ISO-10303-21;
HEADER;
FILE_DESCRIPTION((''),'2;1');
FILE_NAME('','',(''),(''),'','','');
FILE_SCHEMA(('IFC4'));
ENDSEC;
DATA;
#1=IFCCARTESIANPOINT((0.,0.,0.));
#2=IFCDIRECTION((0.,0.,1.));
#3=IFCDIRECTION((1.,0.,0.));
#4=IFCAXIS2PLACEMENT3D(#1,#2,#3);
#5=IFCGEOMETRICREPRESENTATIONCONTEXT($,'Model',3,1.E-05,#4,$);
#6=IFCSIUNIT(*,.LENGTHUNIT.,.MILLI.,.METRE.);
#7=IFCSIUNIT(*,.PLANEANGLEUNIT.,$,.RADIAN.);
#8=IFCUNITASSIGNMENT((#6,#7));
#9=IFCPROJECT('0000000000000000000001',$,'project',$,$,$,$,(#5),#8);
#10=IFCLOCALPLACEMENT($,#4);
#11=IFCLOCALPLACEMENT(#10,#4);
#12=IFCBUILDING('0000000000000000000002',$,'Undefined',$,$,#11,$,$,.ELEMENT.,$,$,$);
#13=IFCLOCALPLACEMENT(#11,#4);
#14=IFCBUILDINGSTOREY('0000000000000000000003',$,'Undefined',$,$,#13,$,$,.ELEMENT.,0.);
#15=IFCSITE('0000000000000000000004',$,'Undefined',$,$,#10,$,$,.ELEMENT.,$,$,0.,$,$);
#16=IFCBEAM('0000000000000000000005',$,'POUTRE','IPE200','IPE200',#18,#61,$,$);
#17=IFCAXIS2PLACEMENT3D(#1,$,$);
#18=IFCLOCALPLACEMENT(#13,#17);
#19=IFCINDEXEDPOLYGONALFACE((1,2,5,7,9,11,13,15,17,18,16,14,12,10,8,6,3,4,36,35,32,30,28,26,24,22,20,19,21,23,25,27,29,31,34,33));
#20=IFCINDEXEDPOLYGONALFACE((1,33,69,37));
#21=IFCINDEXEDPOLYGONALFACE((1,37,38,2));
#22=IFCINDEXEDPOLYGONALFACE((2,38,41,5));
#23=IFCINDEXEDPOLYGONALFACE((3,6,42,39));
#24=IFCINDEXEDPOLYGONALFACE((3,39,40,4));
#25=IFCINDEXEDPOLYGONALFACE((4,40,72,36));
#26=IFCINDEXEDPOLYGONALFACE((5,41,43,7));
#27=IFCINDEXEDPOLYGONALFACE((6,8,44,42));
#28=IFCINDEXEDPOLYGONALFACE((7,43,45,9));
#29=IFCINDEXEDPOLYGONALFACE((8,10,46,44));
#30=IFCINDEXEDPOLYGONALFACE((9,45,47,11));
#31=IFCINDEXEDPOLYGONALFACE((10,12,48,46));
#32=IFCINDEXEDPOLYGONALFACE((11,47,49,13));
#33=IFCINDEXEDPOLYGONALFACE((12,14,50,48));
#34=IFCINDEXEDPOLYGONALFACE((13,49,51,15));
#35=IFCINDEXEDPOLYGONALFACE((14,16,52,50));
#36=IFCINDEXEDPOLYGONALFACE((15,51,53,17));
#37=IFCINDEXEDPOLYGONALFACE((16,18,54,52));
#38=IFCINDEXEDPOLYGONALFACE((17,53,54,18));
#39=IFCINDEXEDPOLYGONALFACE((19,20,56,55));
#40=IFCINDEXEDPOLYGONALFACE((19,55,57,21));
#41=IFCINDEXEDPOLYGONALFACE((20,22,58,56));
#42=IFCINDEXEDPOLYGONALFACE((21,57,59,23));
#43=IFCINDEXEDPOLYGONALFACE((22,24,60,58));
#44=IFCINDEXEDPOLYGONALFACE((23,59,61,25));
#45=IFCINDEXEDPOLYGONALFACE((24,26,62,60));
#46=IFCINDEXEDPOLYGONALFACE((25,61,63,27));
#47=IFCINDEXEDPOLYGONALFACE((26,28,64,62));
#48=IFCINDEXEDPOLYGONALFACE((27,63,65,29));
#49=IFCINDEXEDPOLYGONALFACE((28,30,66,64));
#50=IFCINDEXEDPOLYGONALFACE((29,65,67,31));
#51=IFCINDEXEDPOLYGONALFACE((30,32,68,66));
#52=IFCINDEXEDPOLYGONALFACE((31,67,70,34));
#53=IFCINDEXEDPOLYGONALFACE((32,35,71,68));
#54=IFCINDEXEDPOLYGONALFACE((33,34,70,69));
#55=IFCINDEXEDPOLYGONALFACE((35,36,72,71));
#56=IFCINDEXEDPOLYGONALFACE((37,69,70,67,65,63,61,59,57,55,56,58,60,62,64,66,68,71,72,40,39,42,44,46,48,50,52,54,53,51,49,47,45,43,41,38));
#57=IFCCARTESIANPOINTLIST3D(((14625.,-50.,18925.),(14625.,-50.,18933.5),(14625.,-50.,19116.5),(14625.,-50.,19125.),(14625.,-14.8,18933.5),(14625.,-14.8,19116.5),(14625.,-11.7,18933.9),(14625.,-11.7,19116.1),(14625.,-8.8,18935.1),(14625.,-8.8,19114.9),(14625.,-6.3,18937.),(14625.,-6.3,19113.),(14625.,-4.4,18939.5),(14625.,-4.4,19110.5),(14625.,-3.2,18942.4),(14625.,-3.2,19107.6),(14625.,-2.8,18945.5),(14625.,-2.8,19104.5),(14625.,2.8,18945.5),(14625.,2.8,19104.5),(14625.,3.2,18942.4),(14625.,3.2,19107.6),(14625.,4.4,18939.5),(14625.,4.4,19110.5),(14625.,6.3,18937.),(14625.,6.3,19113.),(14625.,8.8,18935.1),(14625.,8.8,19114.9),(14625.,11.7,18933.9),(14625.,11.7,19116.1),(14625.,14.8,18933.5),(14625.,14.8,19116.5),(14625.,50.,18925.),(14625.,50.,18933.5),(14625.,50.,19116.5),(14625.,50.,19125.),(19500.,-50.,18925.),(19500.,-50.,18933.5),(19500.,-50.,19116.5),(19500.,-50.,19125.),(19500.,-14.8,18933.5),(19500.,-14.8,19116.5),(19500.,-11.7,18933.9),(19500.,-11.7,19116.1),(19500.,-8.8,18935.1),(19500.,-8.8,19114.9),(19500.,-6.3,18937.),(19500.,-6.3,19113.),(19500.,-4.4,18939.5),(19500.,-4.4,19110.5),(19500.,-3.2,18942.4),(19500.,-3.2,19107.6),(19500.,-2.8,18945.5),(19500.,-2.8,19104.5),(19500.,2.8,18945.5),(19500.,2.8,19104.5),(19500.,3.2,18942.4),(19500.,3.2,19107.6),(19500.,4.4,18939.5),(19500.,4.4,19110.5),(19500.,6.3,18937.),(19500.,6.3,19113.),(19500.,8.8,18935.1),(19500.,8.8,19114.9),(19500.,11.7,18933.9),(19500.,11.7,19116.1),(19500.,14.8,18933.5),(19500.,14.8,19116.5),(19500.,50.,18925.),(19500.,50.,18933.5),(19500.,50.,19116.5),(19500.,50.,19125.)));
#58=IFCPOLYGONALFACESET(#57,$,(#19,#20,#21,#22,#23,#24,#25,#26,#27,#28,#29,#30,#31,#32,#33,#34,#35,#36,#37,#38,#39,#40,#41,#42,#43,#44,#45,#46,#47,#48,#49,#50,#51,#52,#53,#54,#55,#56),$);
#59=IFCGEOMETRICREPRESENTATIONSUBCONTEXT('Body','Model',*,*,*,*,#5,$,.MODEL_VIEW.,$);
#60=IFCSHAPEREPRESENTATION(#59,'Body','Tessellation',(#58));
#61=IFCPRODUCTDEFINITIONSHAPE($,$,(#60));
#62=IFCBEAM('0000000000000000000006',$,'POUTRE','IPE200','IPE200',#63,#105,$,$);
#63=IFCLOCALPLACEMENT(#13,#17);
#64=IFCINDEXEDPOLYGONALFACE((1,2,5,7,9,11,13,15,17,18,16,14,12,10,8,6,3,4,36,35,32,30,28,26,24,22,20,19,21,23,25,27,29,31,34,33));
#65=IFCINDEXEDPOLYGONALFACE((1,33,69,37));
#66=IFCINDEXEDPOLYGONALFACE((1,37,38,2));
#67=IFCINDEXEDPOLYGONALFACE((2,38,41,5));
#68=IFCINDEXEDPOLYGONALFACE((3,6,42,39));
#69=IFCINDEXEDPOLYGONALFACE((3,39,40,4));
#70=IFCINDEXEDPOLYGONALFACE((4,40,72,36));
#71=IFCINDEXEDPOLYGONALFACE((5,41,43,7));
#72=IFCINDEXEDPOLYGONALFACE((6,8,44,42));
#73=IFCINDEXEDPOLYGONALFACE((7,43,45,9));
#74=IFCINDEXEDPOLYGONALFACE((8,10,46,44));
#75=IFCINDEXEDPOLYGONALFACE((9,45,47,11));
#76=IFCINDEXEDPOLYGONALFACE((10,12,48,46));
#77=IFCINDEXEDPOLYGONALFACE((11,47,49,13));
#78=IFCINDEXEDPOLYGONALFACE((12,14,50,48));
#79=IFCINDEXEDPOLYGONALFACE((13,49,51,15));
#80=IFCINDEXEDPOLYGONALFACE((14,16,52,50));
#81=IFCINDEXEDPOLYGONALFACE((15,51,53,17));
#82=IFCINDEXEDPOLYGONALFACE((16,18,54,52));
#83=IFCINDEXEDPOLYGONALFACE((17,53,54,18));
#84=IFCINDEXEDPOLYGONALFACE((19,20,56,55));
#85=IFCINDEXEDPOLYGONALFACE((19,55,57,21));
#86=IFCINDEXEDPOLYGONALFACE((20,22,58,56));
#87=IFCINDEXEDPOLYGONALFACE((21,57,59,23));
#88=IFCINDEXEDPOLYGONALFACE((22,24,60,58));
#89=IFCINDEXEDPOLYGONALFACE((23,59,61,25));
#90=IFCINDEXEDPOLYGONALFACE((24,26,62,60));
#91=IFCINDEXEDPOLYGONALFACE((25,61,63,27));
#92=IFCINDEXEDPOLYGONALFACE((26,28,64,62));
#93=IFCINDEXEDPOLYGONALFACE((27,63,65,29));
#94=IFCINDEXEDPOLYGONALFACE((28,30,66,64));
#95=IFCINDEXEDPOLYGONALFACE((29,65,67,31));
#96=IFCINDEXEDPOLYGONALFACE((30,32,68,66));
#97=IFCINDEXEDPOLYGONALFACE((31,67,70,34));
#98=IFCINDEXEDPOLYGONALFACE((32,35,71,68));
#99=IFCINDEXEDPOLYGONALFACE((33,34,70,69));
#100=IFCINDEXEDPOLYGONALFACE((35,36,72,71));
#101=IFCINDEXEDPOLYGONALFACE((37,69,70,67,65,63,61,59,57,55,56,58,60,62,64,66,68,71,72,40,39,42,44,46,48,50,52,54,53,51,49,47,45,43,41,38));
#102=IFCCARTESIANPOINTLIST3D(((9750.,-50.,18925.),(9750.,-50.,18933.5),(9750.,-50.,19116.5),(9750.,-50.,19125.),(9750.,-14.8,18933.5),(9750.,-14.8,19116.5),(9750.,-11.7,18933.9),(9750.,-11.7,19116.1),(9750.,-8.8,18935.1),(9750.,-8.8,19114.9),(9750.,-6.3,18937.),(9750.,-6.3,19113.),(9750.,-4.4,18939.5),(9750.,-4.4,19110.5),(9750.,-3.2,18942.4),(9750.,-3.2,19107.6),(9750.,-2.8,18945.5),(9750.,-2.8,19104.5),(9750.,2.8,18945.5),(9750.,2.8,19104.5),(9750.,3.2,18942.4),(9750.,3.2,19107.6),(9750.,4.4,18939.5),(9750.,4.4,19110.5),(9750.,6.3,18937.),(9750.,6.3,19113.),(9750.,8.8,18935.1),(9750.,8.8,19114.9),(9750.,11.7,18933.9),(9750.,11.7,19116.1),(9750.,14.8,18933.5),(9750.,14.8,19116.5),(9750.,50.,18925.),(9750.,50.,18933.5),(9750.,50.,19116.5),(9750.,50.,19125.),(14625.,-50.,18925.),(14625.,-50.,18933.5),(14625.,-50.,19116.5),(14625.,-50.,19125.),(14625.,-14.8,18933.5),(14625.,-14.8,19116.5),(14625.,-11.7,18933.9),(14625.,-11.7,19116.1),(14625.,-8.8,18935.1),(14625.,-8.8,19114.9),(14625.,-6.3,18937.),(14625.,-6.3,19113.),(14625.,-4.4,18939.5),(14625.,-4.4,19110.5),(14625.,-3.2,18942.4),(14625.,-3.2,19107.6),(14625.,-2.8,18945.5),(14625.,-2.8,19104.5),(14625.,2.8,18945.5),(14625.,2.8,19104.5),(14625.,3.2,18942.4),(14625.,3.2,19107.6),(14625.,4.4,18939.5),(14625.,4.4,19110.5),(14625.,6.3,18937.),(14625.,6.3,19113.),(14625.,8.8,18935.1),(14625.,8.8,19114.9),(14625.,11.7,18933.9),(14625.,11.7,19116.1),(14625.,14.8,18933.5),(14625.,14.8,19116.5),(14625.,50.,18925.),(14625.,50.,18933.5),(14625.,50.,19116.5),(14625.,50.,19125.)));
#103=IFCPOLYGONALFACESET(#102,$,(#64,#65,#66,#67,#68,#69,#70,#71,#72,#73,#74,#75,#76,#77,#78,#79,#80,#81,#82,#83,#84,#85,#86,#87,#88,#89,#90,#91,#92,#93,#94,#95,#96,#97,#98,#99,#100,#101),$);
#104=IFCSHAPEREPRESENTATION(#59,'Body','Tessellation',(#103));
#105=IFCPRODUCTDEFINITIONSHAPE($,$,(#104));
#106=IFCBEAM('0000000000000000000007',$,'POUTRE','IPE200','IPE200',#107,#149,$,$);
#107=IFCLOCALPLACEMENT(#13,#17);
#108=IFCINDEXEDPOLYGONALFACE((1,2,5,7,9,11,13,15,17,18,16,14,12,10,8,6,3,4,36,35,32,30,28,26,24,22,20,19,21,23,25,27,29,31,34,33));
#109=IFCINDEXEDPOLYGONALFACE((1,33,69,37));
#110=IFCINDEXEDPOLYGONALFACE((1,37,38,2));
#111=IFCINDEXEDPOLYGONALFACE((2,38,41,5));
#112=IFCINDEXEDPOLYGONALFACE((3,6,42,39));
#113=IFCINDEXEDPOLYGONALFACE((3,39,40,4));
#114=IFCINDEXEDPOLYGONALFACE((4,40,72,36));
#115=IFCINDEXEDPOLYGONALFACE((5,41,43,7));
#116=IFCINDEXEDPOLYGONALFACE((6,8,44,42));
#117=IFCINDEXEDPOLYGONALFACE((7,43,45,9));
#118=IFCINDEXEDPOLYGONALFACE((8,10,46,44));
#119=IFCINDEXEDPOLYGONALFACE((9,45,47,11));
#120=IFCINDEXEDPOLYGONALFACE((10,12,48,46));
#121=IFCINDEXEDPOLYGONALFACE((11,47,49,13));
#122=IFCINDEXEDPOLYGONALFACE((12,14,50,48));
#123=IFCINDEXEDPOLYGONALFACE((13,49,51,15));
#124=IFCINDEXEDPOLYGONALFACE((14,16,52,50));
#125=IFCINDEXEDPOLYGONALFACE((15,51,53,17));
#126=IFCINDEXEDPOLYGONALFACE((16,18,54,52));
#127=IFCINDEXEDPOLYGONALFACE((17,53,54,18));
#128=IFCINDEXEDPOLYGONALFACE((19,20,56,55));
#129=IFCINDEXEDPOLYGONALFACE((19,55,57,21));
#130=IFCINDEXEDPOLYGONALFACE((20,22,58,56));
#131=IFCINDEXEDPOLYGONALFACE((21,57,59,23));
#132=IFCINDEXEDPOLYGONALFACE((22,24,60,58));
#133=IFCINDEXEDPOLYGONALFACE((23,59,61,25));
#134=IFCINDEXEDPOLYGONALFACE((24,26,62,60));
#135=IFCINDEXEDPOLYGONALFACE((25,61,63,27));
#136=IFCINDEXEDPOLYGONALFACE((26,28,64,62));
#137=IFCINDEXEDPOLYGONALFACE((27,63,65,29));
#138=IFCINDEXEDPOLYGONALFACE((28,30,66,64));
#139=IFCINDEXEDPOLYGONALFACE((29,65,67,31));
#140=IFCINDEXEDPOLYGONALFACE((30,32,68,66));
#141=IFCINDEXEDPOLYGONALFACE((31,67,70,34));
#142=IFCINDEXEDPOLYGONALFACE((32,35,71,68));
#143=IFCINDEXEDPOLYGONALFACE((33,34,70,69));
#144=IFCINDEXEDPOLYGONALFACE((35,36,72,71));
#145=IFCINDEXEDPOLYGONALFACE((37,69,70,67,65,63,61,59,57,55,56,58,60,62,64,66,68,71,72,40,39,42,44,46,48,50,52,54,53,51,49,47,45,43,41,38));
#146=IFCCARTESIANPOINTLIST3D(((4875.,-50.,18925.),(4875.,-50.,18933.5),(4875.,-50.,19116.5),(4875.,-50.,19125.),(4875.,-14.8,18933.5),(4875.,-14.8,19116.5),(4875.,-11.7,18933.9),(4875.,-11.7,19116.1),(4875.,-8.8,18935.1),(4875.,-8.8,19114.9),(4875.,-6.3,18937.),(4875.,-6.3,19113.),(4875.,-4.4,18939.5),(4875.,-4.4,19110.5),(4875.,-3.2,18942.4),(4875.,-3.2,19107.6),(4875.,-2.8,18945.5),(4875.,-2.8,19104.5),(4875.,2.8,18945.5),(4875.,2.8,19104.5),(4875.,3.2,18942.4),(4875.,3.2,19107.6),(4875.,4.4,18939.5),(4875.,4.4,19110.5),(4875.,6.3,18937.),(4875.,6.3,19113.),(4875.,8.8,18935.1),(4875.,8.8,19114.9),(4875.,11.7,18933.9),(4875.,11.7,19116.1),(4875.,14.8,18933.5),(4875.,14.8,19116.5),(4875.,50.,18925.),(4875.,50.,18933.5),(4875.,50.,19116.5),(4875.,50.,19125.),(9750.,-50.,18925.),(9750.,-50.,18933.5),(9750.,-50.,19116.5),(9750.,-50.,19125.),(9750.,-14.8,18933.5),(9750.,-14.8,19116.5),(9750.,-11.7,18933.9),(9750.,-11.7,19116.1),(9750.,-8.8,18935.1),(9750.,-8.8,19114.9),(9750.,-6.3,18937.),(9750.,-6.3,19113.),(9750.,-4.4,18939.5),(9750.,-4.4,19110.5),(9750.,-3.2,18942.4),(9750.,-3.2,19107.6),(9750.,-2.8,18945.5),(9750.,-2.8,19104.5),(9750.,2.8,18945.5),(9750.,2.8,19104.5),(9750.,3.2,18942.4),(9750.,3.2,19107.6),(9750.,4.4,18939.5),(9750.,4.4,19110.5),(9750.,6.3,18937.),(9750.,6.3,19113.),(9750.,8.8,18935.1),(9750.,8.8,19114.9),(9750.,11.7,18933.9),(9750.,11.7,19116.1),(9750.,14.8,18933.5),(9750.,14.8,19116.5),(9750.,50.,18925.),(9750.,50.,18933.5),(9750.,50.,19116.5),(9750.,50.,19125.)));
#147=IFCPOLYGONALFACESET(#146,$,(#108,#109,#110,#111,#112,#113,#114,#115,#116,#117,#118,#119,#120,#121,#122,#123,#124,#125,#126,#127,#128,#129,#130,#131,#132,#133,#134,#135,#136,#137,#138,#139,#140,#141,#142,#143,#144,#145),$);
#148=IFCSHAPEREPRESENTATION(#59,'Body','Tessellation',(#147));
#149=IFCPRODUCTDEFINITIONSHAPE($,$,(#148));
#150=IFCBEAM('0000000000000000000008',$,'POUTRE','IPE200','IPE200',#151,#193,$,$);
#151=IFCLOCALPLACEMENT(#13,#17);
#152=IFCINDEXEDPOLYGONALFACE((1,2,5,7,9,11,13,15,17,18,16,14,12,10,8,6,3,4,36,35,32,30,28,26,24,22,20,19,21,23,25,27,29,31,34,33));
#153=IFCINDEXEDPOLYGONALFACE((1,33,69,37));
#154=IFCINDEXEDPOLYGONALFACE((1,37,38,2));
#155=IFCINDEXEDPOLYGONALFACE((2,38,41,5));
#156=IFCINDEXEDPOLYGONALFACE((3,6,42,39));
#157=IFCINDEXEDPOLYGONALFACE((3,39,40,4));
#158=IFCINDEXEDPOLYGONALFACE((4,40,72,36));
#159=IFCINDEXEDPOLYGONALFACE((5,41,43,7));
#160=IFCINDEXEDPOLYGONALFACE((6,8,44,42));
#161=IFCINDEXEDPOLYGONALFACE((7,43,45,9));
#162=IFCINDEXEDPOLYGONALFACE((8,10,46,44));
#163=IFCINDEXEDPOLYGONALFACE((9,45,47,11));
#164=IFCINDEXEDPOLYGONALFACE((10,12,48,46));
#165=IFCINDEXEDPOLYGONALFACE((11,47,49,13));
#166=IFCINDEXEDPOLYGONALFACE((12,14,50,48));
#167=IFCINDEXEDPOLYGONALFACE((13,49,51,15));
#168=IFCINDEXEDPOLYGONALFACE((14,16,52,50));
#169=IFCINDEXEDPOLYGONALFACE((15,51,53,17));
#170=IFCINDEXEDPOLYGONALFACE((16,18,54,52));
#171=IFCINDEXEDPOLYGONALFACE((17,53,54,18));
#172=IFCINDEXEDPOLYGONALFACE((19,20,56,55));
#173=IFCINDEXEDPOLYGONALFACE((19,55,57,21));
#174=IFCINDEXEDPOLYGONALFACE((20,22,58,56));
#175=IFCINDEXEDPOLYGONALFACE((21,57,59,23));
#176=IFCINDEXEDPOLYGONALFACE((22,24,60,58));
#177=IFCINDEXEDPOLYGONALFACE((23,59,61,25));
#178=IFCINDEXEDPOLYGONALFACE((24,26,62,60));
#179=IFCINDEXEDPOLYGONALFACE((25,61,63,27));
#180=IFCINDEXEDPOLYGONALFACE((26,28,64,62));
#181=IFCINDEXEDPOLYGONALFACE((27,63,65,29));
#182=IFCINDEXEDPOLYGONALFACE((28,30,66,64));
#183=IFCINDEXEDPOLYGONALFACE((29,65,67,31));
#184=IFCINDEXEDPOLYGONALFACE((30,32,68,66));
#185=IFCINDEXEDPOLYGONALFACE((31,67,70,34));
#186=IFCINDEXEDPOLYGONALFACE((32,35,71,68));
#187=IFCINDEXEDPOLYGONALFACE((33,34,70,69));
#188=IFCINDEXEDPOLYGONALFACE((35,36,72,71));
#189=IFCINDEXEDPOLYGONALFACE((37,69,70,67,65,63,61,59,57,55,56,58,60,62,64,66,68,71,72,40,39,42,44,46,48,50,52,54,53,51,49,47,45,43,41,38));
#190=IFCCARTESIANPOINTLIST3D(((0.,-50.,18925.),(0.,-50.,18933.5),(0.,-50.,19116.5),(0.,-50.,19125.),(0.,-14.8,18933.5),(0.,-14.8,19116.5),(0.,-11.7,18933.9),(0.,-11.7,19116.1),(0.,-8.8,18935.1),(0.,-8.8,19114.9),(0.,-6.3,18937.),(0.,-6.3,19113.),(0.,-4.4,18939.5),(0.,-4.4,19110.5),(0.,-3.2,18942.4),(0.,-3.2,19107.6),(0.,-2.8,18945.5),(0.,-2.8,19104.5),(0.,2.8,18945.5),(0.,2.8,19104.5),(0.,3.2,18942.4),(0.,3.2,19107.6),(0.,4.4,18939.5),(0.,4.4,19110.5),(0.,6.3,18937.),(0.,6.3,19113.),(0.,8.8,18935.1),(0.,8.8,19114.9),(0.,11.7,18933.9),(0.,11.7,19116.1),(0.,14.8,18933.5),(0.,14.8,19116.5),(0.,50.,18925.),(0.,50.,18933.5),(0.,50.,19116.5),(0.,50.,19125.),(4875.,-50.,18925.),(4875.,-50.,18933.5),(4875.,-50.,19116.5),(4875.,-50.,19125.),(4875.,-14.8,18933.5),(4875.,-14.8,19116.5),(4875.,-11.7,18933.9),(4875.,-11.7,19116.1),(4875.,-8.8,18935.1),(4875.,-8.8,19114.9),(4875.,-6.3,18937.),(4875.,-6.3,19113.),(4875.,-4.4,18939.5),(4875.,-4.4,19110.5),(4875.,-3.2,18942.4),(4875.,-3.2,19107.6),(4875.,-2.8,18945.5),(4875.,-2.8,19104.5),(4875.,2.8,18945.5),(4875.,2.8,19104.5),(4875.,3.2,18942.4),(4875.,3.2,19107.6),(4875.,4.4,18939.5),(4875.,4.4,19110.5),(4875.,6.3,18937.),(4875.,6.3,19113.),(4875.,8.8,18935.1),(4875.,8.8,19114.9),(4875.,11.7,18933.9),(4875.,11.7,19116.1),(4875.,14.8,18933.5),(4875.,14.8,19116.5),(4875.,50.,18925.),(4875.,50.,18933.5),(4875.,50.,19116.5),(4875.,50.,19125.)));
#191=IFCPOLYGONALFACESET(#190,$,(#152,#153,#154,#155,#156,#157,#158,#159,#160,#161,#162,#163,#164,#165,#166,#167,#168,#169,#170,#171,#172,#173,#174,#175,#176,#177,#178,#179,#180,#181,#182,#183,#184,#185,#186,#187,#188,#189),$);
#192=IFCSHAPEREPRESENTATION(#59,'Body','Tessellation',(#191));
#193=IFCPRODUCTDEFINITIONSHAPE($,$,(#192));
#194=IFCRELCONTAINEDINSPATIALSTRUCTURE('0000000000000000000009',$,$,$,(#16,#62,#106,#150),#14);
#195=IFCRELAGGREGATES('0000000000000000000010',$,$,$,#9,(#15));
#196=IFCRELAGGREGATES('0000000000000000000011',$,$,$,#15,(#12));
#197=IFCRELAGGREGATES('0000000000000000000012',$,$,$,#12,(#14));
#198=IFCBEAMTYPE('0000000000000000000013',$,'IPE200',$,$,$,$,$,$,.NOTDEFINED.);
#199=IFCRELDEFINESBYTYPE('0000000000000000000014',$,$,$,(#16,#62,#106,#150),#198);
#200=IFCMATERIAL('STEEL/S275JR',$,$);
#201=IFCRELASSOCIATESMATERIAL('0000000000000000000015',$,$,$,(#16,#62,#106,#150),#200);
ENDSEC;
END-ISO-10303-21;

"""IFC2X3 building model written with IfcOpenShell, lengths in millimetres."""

from ifc_helpers import new_model, si_unit, frame, origin_with_axes, origin_2d_with_axis, place, context, subcontext, project, spatial, i_section, extrude, material, type_object, element, save


model = new_model("IFC2X3")

# Units and contexts
model_context = context("Model", 3, precision=1e-05, world=origin_with_axes())
body_context = subcontext(model_context, "Body", "Model", "MODEL_VIEW")
ifc_project = project(units=[si_unit("LENGTHUNIT", "METRE", prefix="MILLI"), si_unit("PLANEANGLEUNIT", "RADIAN")], contexts=[model_context])

# Site, building, storey
site_placement = place(None, origin_with_axes())
site = spatial("IfcSite", under=ifc_project, at=site_placement, Name="Undefined", CompositionType="ELEMENT", RefElevation=0.0)
building_placement = place(site_placement, origin_with_axes())
building = spatial("IfcBuilding", under=site, at=building_placement, Name="Undefined", CompositionType="ELEMENT")
storey_placement = place(building_placement, origin_with_axes())
storey = spatial("IfcBuildingStorey", under=building, at=storey_placement, Name="Undefined", CompositionType="ELEMENT", Elevation=0.0)

# Shared definitions
ifc_material_1 = material(Name="STEEL/S275JR")

# Beams
beam_type_1 = type_object("IfcBeamType", Name="IPE200", PredefinedType="NOTDEFINED")
for number, where, z_axis, x_axis, name in (
    (1, (14625.0, 0.0, 19025.0), (0.000006, 0.0, 1.0), (1.0, 0.0, -0.000006), "POUTRE"),
    (2, (9750.0, 0.0, 19025.0), (-0.000006, 0.0, 1.0), (1.0, 0.0, 0.000006), "POUTRE"),
    (3, (4875.0, 0.0, 19025.0), (0.000006, 0.0, 1.0), (1.0, 0.0, -0.000006), "POUTRE"),
    (4, (0.0, 0.0, 19025.0), (-0.000006, 0.0, 1.0), (1.0, 0.0, 0.000006), "POUTRE"),
):
    element("IfcBeam", number, at=place(storey_placement, frame(where, z_axis=z_axis, x_axis=x_axis)), inside=storey, type_object=beam_type_1, material=ifc_material_1, Name=name, Description="IPE200", ObjectType="IPE200", context=body_context, shape_type="SweptSolid", body=[
        extrude(i_section(OverallWidth=100.0, OverallDepth=200.0, WebThickness=5.6, FlangeThickness=8.5, FilletRadius=12.0, at=origin_2d_with_axis()), frame((4875.0, 0.0, 0.0), z_axis=(-1.0, 0.0, 0.0), x_axis=(0.0, -1.0, 0.0)), (0.0, 0.0, 1.0), 4875.0),
    ])

save(model, "model.ifc")
